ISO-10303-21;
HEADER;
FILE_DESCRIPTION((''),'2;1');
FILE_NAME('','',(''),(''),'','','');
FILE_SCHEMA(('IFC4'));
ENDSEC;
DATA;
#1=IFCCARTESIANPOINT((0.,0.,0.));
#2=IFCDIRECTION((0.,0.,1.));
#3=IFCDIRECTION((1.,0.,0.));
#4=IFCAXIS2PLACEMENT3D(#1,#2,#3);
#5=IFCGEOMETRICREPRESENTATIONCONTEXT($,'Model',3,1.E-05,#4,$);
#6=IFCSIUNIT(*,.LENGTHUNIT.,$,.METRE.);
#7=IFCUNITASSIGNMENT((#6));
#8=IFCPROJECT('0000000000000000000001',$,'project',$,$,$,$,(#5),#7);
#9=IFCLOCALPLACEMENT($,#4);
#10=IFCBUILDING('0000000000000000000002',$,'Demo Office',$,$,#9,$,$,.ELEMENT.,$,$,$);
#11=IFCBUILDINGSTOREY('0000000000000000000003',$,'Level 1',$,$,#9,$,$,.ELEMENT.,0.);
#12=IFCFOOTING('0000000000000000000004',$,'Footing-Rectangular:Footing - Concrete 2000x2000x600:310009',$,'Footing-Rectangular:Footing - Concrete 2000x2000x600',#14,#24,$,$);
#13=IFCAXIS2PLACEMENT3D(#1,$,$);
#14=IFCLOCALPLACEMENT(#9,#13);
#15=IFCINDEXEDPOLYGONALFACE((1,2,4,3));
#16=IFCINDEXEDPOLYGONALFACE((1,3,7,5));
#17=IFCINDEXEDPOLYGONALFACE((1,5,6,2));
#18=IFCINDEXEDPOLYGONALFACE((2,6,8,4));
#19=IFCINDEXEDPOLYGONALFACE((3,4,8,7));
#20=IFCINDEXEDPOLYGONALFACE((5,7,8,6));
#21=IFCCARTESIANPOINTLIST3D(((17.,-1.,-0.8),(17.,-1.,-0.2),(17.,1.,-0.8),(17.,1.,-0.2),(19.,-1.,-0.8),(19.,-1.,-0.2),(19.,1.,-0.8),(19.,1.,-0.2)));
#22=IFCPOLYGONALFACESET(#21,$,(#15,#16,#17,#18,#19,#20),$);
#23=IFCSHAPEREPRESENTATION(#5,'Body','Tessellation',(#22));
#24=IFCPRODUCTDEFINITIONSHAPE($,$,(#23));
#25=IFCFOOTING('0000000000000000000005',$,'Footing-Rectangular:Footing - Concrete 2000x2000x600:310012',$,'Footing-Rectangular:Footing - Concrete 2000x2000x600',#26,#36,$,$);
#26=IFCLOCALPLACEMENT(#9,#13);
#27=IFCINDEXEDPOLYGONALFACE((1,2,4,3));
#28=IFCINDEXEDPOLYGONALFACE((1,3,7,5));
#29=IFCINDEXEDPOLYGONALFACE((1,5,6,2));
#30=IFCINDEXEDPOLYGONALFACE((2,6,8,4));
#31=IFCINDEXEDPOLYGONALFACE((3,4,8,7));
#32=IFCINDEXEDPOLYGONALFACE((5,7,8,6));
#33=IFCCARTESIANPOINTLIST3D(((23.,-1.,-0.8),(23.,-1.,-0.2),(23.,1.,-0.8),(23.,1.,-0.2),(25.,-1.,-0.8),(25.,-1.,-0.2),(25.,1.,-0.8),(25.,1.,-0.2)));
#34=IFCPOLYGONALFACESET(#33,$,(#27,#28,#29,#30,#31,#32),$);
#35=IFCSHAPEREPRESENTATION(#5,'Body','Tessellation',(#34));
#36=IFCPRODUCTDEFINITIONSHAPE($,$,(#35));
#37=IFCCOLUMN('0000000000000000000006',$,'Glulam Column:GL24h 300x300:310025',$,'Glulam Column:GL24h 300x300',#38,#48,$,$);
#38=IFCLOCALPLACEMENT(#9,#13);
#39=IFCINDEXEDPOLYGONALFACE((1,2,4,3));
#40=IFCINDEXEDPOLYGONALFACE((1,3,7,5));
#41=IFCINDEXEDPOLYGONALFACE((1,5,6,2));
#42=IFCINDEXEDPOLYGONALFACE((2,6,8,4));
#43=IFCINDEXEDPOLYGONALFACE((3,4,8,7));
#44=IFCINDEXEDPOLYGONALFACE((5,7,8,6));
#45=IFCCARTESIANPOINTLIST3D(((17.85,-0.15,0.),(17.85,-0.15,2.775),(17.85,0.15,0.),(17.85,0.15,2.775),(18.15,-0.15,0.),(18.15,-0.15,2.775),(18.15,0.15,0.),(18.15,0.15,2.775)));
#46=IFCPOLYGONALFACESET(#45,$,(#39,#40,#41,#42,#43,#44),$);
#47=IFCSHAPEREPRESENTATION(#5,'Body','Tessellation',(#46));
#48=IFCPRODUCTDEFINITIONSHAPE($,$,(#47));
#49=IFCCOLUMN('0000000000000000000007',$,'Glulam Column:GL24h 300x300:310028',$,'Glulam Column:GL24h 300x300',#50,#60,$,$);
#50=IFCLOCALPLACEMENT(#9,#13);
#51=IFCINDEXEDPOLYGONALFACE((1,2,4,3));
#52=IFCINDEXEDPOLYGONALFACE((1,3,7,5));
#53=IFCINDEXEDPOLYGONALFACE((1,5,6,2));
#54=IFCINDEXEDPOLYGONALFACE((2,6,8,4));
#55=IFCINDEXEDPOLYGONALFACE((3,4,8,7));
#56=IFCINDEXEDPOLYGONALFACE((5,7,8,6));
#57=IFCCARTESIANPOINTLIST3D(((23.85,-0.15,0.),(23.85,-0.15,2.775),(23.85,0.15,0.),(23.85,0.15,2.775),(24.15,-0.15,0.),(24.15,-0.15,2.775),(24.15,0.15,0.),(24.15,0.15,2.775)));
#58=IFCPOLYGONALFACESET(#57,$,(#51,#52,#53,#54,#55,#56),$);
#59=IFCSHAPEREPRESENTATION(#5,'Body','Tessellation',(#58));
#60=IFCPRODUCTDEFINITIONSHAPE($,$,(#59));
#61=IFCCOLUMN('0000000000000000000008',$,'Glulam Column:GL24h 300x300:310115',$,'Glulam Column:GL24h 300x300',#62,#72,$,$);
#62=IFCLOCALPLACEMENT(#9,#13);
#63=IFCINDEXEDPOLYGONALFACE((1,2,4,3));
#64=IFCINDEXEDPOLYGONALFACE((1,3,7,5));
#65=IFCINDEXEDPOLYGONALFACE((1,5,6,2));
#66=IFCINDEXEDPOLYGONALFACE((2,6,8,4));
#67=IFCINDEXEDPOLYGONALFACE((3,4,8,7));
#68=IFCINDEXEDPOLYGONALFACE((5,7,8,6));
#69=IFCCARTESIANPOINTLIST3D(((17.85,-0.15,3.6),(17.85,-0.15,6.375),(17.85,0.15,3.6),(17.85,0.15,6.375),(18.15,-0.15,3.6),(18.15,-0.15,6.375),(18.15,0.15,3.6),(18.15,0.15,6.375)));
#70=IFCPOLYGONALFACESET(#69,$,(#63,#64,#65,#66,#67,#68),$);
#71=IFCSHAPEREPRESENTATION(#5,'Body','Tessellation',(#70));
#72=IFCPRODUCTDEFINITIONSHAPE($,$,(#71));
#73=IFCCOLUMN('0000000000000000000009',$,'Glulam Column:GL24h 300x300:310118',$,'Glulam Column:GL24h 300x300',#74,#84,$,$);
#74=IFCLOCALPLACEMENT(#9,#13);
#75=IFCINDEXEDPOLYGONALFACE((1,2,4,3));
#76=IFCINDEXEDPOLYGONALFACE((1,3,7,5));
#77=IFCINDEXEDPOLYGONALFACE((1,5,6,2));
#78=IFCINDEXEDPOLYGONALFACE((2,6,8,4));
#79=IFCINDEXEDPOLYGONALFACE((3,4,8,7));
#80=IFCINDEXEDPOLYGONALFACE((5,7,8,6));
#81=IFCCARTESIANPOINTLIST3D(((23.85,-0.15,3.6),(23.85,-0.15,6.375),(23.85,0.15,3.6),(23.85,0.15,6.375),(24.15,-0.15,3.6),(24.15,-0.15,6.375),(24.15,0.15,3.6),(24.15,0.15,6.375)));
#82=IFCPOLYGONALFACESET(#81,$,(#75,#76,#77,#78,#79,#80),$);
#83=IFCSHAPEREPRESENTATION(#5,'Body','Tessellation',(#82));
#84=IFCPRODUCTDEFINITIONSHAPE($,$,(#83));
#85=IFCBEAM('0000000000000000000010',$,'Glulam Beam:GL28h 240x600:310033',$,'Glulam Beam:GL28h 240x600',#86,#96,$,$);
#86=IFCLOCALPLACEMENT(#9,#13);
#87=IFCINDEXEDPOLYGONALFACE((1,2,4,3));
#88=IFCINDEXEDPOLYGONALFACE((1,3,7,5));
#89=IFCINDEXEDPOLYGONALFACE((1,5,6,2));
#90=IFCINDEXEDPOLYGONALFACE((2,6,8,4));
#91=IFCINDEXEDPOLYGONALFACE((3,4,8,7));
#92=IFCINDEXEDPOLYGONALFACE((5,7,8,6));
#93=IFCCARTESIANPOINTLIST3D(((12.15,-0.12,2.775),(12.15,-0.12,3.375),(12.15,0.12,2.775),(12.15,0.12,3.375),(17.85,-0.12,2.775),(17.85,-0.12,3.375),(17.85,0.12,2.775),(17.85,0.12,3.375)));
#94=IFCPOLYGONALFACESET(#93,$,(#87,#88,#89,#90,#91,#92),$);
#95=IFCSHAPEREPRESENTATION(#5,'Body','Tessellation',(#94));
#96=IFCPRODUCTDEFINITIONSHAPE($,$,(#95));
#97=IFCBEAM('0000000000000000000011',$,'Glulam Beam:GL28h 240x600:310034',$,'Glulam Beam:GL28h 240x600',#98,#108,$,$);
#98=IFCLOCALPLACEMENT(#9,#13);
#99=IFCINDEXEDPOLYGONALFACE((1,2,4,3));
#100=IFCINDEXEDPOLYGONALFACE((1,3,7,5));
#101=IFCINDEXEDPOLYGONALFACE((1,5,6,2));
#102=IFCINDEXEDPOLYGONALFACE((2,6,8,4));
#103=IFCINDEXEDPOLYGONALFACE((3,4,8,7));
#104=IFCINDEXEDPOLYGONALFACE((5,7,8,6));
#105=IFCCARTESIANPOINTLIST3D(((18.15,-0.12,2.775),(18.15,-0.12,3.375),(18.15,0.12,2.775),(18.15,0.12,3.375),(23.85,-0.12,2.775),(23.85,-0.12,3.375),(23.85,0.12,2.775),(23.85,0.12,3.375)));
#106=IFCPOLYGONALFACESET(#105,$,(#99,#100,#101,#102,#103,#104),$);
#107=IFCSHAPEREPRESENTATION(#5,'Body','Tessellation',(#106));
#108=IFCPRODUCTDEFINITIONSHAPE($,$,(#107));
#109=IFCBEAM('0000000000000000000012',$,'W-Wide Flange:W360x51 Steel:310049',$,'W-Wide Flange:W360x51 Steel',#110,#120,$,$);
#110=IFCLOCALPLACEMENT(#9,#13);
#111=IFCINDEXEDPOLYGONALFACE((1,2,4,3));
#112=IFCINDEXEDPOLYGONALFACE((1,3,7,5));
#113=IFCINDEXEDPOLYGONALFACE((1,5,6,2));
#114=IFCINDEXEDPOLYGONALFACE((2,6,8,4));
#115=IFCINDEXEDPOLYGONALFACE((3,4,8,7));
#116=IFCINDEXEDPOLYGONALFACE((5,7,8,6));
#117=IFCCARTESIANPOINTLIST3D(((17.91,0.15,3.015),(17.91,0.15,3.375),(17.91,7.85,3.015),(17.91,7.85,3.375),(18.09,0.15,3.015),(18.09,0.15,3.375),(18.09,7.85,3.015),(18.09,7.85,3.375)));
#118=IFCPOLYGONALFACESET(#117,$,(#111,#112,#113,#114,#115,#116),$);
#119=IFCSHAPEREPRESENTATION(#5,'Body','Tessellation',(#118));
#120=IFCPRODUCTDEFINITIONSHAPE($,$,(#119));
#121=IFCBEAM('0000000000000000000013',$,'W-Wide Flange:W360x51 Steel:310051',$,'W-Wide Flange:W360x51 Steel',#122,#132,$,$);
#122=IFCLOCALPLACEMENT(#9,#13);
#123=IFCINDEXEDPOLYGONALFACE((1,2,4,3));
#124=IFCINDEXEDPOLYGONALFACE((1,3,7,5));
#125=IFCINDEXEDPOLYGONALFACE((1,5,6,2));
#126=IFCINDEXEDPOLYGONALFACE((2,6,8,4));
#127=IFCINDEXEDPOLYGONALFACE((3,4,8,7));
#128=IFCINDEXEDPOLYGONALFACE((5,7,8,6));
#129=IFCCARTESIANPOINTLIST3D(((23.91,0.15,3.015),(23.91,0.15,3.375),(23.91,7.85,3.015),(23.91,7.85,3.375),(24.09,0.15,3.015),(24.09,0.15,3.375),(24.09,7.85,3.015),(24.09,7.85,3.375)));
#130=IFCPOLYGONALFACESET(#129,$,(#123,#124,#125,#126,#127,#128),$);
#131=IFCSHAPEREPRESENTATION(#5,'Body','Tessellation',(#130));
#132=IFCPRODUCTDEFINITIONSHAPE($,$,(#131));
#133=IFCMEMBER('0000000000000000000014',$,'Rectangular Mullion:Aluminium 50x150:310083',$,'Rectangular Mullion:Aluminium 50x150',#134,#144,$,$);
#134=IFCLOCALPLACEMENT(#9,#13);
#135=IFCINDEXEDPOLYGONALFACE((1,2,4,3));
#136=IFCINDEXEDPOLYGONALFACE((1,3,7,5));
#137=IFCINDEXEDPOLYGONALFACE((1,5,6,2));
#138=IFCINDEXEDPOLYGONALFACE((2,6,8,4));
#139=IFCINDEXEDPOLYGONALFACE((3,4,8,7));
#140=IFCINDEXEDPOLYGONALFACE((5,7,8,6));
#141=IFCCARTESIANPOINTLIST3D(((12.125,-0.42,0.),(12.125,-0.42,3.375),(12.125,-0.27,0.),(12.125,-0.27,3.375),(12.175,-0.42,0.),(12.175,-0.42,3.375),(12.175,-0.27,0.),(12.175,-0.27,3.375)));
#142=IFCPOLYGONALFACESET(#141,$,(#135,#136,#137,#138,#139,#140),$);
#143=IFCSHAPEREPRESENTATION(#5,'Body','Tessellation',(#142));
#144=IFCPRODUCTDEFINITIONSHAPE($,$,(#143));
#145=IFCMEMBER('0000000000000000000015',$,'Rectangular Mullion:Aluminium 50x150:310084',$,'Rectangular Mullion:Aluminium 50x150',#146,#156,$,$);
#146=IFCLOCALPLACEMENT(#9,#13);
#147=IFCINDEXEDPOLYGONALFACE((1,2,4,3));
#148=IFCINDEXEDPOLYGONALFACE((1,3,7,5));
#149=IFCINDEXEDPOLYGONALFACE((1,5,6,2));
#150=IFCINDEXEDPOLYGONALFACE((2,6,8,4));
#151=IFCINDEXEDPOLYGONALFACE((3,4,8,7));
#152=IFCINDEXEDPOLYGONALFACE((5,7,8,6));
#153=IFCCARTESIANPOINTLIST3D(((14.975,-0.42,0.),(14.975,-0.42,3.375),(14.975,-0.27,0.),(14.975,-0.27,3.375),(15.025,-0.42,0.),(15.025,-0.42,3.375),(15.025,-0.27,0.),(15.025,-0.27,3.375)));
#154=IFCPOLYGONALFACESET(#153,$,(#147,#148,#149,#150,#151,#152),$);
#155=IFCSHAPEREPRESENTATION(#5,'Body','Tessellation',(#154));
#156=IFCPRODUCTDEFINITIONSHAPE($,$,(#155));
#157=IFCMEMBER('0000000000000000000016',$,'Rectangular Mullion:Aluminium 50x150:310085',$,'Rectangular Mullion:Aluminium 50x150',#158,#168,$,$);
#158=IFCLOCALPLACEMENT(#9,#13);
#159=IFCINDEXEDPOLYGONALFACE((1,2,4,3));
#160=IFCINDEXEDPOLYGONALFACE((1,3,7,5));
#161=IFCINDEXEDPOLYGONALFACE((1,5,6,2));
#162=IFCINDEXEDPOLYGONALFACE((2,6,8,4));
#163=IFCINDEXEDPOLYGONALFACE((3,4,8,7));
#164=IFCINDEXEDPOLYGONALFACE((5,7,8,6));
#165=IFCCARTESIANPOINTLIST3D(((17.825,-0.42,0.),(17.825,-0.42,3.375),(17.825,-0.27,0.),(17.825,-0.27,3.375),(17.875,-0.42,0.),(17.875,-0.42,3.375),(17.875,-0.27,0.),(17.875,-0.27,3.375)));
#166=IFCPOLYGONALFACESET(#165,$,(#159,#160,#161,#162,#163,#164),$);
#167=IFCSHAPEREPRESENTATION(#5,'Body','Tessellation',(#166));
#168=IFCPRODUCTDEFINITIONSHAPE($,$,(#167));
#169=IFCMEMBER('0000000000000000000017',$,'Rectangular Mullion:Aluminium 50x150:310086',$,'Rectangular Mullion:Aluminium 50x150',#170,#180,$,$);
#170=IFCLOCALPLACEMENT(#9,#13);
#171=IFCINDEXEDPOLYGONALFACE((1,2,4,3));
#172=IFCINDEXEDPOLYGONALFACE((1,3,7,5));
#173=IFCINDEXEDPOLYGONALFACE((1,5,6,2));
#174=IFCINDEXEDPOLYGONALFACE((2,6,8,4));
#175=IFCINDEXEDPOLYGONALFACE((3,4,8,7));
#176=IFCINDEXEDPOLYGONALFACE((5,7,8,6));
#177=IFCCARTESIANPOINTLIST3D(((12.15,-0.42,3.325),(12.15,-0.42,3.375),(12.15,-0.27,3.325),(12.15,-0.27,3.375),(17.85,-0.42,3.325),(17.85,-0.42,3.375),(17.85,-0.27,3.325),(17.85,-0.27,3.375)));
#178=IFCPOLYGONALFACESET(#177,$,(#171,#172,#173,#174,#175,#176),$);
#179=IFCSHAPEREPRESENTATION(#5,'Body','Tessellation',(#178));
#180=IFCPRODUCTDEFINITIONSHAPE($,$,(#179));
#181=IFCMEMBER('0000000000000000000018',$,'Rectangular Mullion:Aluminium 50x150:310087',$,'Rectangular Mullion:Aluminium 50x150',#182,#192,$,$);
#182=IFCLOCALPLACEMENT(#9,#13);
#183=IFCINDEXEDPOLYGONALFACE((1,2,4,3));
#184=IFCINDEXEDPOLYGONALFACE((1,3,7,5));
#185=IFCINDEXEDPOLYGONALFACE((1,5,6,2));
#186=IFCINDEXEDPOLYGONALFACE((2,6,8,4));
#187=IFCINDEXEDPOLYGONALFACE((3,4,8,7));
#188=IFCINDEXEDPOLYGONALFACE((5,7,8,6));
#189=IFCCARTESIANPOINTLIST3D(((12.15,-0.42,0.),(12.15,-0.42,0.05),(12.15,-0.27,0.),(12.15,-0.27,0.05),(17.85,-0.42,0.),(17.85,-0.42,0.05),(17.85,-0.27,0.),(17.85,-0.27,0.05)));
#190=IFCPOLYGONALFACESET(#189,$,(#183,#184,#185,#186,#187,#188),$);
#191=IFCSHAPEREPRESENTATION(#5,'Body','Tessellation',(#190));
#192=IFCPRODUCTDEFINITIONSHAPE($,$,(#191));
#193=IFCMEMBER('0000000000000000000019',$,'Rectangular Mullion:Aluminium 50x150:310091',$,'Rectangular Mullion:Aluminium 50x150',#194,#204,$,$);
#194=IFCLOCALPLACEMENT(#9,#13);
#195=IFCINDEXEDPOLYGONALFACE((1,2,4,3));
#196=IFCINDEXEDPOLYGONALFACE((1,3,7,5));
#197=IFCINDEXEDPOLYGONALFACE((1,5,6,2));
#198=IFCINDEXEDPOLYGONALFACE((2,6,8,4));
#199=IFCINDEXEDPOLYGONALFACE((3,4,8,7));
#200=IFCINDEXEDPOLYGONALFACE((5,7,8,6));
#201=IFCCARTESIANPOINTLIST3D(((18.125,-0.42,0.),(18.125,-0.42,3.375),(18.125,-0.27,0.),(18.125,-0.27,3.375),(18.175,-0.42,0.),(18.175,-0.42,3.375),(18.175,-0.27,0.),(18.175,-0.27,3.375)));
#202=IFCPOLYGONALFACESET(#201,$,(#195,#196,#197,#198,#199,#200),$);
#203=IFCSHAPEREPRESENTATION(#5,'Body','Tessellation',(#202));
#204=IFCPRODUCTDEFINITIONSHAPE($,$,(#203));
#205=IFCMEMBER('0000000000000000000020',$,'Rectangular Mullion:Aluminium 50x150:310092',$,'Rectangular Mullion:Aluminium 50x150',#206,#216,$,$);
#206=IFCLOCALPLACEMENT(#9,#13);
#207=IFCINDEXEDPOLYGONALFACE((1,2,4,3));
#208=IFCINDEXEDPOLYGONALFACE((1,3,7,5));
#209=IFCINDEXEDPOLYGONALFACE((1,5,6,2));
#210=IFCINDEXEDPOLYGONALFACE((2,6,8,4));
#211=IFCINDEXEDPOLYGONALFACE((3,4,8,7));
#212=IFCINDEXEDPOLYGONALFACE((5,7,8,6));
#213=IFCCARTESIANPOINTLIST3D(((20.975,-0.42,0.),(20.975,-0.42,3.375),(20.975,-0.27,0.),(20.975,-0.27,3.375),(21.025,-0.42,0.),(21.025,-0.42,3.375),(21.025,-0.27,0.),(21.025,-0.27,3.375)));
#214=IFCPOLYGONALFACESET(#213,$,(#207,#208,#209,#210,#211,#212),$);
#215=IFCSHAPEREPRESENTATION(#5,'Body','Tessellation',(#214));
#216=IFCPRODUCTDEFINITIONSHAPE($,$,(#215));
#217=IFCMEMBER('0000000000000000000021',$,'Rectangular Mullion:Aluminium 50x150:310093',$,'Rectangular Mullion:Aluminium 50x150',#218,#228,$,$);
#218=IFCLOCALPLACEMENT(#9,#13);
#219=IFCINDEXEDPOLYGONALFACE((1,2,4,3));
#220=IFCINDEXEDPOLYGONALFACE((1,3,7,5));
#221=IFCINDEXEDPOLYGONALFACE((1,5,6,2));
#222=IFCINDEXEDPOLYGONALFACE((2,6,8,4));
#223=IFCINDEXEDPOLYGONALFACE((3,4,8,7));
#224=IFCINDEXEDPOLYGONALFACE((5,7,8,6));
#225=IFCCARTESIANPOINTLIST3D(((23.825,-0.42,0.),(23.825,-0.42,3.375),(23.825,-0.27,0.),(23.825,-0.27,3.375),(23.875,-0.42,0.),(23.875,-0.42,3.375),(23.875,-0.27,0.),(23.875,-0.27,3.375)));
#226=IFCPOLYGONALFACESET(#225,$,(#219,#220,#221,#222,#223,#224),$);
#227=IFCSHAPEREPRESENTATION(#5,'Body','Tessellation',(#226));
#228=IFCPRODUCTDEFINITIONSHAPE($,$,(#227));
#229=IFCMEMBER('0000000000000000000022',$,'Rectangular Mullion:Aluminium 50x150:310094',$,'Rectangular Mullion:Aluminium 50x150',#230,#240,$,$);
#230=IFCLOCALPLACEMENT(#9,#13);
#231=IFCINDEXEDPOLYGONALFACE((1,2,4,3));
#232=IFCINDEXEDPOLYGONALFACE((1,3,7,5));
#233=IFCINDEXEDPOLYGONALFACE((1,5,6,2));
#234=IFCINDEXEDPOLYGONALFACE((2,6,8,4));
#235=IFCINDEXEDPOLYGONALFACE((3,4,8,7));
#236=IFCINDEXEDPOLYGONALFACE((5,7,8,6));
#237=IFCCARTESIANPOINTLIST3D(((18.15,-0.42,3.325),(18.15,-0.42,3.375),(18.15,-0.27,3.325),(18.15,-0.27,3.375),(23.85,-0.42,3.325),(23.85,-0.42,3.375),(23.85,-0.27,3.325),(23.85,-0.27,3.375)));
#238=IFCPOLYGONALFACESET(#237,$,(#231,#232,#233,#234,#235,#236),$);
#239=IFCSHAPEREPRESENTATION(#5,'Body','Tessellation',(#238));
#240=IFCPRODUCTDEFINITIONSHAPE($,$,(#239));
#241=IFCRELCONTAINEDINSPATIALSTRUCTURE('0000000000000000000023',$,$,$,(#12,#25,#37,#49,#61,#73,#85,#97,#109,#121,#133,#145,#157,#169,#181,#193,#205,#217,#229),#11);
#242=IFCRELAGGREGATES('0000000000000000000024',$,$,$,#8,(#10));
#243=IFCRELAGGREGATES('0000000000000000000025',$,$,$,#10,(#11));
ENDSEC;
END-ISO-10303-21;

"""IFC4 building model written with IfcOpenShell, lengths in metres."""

from ifc_helpers import new_model, si_unit, frame, origin_with_axes, origin_2d, place, context, project, spatial, rectangle, extrude, element, save


model = new_model("IFC4")

# Units and contexts
model_context = context("Model", 3, precision=1e-05, world=origin_with_axes())
ifc_project = project(units=[si_unit("LENGTHUNIT", "METRE")], contexts=[model_context])

# Building, storey
placement = place(None, origin_with_axes())
building = spatial("IfcBuilding", under=ifc_project, at=placement, Name="Demo Office", CompositionType="ELEMENT")
storey = spatial("IfcBuildingStorey", under=building, at=placement, Name="Level 1", CompositionType="ELEMENT", Elevation=0.0)

# Footings
for number, where, name in (
    (1, (18.0, 0.0, -0.8), "Footing-Rectangular:Footing - Concrete 2000x2000x600:310009"),
    (2, (24.0, 0.0, -0.8), "Footing-Rectangular:Footing - Concrete 2000x2000x600:310012"),
):
    element("IfcFooting", number, at=place(placement, frame(where)), inside=storey, Name=name, ObjectType="Footing-Rectangular:Footing - Concrete 2000x2000x600", context=model_context, shape_type="SweptSolid", body=[
        extrude(rectangle(XDim=2.0, YDim=2.0, at=origin_2d()), origin_with_axes(), (0.0, 0.0, 1.0), 0.6),
    ])

# Columns
for number, where, name in (
    (3, (18.0, 0.0, 0.0), "Glulam Column:GL24h 300x300:310025"),
    (4, (24.0, 0.0, 0.0), "Glulam Column:GL24h 300x300:310028"),
    (5, (18.0, 0.0, 3.6), "Glulam Column:GL24h 300x300:310115"),
    (6, (24.0, 0.0, 3.6), "Glulam Column:GL24h 300x300:310118"),
):
    element("IfcColumn", number, at=place(placement, frame(where)), inside=storey, Name=name, ObjectType="Glulam Column:GL24h 300x300", context=model_context, shape_type="SweptSolid", body=[
        extrude(rectangle(XDim=0.3, YDim=0.3, at=origin_2d()), origin_with_axes(), (0.0, 0.0, 1.0), 2.775),
    ])

# Beams
for number, where, name in (
    (7, (15.0, 0.0, 2.775), "Glulam Beam:GL28h 240x600:310033"),
    (8, (21.0, 0.0, 2.775), "Glulam Beam:GL28h 240x600:310034"),
):
    element("IfcBeam", number, at=place(placement, frame(where)), inside=storey, Name=name, ObjectType="Glulam Beam:GL28h 240x600", context=model_context, shape_type="SweptSolid", body=[
        extrude(rectangle(XDim=5.7, YDim=0.24, at=origin_2d()), origin_with_axes(), (0.0, 0.0, 1.0), 0.6),
    ])
for number, where, name in (
    (9, (18.0, 4.0, 3.015), "W-Wide Flange:W360x51 Steel:310049"),
    (10, (24.0, 4.0, 3.015), "W-Wide Flange:W360x51 Steel:310051"),
):
    element("IfcBeam", number, at=place(placement, frame(where)), inside=storey, Name=name, ObjectType="W-Wide Flange:W360x51 Steel", context=model_context, shape_type="SweptSolid", body=[
        extrude(rectangle(XDim=0.18, YDim=7.7, at=origin_2d()), origin_with_axes(), (0.0, 0.0, 1.0), 0.36),
    ])

# Members
for number, where, name in (
    (11, (12.15, -0.345, 0.0), "Rectangular Mullion:Aluminium 50x150:310083"),
    (12, (15.0, -0.345, 0.0), "Rectangular Mullion:Aluminium 50x150:310084"),
    (13, (17.85, -0.345, 0.0), "Rectangular Mullion:Aluminium 50x150:310085"),
):
    element("IfcMember", number, at=place(placement, frame(where)), inside=storey, Name=name, ObjectType="Rectangular Mullion:Aluminium 50x150", context=model_context, shape_type="SweptSolid", body=[
        extrude(rectangle(XDim=0.05, YDim=0.15, at=origin_2d()), origin_with_axes(), (0.0, 0.0, 1.0), 3.375),
    ])
for number, where, name in (
    (14, (15.0, -0.345, 3.325), "Rectangular Mullion:Aluminium 50x150:310086"),
    (15, (15.0, -0.345, 0.0), "Rectangular Mullion:Aluminium 50x150:310087"),
):
    element("IfcMember", number, at=place(placement, frame(where)), inside=storey, Name=name, ObjectType="Rectangular Mullion:Aluminium 50x150", context=model_context, shape_type="SweptSolid", body=[
        extrude(rectangle(XDim=5.7, YDim=0.15, at=origin_2d()), origin_with_axes(), (0.0, 0.0, 1.0), 0.05),
    ])
for number, where, name in (
    (16, (18.15, -0.345, 0.0), "Rectangular Mullion:Aluminium 50x150:310091"),
    (17, (21.0, -0.345, 0.0), "Rectangular Mullion:Aluminium 50x150:310092"),
    (18, (23.85, -0.345, 0.0), "Rectangular Mullion:Aluminium 50x150:310093"),
):
    element("IfcMember", number, at=place(placement, frame(where)), inside=storey, Name=name, ObjectType="Rectangular Mullion:Aluminium 50x150", context=model_context, shape_type="SweptSolid", body=[
        extrude(rectangle(XDim=0.05, YDim=0.15, at=origin_2d()), origin_with_axes(), (0.0, 0.0, 1.0), 3.375),
    ])
for number, where, name in (
    (19, (21.0, -0.345, 3.325), "Rectangular Mullion:Aluminium 50x150:310094"),
):
    element("IfcMember", number, at=place(placement, frame(where)), inside=storey, Name=name, ObjectType="Rectangular Mullion:Aluminium 50x150", context=model_context, shape_type="SweptSolid", body=[
        extrude(rectangle(XDim=5.7, YDim=0.15, at=origin_2d()), origin_with_axes(), (0.0, 0.0, 1.0), 0.05),
    ])

save(model, "model.ifc")
